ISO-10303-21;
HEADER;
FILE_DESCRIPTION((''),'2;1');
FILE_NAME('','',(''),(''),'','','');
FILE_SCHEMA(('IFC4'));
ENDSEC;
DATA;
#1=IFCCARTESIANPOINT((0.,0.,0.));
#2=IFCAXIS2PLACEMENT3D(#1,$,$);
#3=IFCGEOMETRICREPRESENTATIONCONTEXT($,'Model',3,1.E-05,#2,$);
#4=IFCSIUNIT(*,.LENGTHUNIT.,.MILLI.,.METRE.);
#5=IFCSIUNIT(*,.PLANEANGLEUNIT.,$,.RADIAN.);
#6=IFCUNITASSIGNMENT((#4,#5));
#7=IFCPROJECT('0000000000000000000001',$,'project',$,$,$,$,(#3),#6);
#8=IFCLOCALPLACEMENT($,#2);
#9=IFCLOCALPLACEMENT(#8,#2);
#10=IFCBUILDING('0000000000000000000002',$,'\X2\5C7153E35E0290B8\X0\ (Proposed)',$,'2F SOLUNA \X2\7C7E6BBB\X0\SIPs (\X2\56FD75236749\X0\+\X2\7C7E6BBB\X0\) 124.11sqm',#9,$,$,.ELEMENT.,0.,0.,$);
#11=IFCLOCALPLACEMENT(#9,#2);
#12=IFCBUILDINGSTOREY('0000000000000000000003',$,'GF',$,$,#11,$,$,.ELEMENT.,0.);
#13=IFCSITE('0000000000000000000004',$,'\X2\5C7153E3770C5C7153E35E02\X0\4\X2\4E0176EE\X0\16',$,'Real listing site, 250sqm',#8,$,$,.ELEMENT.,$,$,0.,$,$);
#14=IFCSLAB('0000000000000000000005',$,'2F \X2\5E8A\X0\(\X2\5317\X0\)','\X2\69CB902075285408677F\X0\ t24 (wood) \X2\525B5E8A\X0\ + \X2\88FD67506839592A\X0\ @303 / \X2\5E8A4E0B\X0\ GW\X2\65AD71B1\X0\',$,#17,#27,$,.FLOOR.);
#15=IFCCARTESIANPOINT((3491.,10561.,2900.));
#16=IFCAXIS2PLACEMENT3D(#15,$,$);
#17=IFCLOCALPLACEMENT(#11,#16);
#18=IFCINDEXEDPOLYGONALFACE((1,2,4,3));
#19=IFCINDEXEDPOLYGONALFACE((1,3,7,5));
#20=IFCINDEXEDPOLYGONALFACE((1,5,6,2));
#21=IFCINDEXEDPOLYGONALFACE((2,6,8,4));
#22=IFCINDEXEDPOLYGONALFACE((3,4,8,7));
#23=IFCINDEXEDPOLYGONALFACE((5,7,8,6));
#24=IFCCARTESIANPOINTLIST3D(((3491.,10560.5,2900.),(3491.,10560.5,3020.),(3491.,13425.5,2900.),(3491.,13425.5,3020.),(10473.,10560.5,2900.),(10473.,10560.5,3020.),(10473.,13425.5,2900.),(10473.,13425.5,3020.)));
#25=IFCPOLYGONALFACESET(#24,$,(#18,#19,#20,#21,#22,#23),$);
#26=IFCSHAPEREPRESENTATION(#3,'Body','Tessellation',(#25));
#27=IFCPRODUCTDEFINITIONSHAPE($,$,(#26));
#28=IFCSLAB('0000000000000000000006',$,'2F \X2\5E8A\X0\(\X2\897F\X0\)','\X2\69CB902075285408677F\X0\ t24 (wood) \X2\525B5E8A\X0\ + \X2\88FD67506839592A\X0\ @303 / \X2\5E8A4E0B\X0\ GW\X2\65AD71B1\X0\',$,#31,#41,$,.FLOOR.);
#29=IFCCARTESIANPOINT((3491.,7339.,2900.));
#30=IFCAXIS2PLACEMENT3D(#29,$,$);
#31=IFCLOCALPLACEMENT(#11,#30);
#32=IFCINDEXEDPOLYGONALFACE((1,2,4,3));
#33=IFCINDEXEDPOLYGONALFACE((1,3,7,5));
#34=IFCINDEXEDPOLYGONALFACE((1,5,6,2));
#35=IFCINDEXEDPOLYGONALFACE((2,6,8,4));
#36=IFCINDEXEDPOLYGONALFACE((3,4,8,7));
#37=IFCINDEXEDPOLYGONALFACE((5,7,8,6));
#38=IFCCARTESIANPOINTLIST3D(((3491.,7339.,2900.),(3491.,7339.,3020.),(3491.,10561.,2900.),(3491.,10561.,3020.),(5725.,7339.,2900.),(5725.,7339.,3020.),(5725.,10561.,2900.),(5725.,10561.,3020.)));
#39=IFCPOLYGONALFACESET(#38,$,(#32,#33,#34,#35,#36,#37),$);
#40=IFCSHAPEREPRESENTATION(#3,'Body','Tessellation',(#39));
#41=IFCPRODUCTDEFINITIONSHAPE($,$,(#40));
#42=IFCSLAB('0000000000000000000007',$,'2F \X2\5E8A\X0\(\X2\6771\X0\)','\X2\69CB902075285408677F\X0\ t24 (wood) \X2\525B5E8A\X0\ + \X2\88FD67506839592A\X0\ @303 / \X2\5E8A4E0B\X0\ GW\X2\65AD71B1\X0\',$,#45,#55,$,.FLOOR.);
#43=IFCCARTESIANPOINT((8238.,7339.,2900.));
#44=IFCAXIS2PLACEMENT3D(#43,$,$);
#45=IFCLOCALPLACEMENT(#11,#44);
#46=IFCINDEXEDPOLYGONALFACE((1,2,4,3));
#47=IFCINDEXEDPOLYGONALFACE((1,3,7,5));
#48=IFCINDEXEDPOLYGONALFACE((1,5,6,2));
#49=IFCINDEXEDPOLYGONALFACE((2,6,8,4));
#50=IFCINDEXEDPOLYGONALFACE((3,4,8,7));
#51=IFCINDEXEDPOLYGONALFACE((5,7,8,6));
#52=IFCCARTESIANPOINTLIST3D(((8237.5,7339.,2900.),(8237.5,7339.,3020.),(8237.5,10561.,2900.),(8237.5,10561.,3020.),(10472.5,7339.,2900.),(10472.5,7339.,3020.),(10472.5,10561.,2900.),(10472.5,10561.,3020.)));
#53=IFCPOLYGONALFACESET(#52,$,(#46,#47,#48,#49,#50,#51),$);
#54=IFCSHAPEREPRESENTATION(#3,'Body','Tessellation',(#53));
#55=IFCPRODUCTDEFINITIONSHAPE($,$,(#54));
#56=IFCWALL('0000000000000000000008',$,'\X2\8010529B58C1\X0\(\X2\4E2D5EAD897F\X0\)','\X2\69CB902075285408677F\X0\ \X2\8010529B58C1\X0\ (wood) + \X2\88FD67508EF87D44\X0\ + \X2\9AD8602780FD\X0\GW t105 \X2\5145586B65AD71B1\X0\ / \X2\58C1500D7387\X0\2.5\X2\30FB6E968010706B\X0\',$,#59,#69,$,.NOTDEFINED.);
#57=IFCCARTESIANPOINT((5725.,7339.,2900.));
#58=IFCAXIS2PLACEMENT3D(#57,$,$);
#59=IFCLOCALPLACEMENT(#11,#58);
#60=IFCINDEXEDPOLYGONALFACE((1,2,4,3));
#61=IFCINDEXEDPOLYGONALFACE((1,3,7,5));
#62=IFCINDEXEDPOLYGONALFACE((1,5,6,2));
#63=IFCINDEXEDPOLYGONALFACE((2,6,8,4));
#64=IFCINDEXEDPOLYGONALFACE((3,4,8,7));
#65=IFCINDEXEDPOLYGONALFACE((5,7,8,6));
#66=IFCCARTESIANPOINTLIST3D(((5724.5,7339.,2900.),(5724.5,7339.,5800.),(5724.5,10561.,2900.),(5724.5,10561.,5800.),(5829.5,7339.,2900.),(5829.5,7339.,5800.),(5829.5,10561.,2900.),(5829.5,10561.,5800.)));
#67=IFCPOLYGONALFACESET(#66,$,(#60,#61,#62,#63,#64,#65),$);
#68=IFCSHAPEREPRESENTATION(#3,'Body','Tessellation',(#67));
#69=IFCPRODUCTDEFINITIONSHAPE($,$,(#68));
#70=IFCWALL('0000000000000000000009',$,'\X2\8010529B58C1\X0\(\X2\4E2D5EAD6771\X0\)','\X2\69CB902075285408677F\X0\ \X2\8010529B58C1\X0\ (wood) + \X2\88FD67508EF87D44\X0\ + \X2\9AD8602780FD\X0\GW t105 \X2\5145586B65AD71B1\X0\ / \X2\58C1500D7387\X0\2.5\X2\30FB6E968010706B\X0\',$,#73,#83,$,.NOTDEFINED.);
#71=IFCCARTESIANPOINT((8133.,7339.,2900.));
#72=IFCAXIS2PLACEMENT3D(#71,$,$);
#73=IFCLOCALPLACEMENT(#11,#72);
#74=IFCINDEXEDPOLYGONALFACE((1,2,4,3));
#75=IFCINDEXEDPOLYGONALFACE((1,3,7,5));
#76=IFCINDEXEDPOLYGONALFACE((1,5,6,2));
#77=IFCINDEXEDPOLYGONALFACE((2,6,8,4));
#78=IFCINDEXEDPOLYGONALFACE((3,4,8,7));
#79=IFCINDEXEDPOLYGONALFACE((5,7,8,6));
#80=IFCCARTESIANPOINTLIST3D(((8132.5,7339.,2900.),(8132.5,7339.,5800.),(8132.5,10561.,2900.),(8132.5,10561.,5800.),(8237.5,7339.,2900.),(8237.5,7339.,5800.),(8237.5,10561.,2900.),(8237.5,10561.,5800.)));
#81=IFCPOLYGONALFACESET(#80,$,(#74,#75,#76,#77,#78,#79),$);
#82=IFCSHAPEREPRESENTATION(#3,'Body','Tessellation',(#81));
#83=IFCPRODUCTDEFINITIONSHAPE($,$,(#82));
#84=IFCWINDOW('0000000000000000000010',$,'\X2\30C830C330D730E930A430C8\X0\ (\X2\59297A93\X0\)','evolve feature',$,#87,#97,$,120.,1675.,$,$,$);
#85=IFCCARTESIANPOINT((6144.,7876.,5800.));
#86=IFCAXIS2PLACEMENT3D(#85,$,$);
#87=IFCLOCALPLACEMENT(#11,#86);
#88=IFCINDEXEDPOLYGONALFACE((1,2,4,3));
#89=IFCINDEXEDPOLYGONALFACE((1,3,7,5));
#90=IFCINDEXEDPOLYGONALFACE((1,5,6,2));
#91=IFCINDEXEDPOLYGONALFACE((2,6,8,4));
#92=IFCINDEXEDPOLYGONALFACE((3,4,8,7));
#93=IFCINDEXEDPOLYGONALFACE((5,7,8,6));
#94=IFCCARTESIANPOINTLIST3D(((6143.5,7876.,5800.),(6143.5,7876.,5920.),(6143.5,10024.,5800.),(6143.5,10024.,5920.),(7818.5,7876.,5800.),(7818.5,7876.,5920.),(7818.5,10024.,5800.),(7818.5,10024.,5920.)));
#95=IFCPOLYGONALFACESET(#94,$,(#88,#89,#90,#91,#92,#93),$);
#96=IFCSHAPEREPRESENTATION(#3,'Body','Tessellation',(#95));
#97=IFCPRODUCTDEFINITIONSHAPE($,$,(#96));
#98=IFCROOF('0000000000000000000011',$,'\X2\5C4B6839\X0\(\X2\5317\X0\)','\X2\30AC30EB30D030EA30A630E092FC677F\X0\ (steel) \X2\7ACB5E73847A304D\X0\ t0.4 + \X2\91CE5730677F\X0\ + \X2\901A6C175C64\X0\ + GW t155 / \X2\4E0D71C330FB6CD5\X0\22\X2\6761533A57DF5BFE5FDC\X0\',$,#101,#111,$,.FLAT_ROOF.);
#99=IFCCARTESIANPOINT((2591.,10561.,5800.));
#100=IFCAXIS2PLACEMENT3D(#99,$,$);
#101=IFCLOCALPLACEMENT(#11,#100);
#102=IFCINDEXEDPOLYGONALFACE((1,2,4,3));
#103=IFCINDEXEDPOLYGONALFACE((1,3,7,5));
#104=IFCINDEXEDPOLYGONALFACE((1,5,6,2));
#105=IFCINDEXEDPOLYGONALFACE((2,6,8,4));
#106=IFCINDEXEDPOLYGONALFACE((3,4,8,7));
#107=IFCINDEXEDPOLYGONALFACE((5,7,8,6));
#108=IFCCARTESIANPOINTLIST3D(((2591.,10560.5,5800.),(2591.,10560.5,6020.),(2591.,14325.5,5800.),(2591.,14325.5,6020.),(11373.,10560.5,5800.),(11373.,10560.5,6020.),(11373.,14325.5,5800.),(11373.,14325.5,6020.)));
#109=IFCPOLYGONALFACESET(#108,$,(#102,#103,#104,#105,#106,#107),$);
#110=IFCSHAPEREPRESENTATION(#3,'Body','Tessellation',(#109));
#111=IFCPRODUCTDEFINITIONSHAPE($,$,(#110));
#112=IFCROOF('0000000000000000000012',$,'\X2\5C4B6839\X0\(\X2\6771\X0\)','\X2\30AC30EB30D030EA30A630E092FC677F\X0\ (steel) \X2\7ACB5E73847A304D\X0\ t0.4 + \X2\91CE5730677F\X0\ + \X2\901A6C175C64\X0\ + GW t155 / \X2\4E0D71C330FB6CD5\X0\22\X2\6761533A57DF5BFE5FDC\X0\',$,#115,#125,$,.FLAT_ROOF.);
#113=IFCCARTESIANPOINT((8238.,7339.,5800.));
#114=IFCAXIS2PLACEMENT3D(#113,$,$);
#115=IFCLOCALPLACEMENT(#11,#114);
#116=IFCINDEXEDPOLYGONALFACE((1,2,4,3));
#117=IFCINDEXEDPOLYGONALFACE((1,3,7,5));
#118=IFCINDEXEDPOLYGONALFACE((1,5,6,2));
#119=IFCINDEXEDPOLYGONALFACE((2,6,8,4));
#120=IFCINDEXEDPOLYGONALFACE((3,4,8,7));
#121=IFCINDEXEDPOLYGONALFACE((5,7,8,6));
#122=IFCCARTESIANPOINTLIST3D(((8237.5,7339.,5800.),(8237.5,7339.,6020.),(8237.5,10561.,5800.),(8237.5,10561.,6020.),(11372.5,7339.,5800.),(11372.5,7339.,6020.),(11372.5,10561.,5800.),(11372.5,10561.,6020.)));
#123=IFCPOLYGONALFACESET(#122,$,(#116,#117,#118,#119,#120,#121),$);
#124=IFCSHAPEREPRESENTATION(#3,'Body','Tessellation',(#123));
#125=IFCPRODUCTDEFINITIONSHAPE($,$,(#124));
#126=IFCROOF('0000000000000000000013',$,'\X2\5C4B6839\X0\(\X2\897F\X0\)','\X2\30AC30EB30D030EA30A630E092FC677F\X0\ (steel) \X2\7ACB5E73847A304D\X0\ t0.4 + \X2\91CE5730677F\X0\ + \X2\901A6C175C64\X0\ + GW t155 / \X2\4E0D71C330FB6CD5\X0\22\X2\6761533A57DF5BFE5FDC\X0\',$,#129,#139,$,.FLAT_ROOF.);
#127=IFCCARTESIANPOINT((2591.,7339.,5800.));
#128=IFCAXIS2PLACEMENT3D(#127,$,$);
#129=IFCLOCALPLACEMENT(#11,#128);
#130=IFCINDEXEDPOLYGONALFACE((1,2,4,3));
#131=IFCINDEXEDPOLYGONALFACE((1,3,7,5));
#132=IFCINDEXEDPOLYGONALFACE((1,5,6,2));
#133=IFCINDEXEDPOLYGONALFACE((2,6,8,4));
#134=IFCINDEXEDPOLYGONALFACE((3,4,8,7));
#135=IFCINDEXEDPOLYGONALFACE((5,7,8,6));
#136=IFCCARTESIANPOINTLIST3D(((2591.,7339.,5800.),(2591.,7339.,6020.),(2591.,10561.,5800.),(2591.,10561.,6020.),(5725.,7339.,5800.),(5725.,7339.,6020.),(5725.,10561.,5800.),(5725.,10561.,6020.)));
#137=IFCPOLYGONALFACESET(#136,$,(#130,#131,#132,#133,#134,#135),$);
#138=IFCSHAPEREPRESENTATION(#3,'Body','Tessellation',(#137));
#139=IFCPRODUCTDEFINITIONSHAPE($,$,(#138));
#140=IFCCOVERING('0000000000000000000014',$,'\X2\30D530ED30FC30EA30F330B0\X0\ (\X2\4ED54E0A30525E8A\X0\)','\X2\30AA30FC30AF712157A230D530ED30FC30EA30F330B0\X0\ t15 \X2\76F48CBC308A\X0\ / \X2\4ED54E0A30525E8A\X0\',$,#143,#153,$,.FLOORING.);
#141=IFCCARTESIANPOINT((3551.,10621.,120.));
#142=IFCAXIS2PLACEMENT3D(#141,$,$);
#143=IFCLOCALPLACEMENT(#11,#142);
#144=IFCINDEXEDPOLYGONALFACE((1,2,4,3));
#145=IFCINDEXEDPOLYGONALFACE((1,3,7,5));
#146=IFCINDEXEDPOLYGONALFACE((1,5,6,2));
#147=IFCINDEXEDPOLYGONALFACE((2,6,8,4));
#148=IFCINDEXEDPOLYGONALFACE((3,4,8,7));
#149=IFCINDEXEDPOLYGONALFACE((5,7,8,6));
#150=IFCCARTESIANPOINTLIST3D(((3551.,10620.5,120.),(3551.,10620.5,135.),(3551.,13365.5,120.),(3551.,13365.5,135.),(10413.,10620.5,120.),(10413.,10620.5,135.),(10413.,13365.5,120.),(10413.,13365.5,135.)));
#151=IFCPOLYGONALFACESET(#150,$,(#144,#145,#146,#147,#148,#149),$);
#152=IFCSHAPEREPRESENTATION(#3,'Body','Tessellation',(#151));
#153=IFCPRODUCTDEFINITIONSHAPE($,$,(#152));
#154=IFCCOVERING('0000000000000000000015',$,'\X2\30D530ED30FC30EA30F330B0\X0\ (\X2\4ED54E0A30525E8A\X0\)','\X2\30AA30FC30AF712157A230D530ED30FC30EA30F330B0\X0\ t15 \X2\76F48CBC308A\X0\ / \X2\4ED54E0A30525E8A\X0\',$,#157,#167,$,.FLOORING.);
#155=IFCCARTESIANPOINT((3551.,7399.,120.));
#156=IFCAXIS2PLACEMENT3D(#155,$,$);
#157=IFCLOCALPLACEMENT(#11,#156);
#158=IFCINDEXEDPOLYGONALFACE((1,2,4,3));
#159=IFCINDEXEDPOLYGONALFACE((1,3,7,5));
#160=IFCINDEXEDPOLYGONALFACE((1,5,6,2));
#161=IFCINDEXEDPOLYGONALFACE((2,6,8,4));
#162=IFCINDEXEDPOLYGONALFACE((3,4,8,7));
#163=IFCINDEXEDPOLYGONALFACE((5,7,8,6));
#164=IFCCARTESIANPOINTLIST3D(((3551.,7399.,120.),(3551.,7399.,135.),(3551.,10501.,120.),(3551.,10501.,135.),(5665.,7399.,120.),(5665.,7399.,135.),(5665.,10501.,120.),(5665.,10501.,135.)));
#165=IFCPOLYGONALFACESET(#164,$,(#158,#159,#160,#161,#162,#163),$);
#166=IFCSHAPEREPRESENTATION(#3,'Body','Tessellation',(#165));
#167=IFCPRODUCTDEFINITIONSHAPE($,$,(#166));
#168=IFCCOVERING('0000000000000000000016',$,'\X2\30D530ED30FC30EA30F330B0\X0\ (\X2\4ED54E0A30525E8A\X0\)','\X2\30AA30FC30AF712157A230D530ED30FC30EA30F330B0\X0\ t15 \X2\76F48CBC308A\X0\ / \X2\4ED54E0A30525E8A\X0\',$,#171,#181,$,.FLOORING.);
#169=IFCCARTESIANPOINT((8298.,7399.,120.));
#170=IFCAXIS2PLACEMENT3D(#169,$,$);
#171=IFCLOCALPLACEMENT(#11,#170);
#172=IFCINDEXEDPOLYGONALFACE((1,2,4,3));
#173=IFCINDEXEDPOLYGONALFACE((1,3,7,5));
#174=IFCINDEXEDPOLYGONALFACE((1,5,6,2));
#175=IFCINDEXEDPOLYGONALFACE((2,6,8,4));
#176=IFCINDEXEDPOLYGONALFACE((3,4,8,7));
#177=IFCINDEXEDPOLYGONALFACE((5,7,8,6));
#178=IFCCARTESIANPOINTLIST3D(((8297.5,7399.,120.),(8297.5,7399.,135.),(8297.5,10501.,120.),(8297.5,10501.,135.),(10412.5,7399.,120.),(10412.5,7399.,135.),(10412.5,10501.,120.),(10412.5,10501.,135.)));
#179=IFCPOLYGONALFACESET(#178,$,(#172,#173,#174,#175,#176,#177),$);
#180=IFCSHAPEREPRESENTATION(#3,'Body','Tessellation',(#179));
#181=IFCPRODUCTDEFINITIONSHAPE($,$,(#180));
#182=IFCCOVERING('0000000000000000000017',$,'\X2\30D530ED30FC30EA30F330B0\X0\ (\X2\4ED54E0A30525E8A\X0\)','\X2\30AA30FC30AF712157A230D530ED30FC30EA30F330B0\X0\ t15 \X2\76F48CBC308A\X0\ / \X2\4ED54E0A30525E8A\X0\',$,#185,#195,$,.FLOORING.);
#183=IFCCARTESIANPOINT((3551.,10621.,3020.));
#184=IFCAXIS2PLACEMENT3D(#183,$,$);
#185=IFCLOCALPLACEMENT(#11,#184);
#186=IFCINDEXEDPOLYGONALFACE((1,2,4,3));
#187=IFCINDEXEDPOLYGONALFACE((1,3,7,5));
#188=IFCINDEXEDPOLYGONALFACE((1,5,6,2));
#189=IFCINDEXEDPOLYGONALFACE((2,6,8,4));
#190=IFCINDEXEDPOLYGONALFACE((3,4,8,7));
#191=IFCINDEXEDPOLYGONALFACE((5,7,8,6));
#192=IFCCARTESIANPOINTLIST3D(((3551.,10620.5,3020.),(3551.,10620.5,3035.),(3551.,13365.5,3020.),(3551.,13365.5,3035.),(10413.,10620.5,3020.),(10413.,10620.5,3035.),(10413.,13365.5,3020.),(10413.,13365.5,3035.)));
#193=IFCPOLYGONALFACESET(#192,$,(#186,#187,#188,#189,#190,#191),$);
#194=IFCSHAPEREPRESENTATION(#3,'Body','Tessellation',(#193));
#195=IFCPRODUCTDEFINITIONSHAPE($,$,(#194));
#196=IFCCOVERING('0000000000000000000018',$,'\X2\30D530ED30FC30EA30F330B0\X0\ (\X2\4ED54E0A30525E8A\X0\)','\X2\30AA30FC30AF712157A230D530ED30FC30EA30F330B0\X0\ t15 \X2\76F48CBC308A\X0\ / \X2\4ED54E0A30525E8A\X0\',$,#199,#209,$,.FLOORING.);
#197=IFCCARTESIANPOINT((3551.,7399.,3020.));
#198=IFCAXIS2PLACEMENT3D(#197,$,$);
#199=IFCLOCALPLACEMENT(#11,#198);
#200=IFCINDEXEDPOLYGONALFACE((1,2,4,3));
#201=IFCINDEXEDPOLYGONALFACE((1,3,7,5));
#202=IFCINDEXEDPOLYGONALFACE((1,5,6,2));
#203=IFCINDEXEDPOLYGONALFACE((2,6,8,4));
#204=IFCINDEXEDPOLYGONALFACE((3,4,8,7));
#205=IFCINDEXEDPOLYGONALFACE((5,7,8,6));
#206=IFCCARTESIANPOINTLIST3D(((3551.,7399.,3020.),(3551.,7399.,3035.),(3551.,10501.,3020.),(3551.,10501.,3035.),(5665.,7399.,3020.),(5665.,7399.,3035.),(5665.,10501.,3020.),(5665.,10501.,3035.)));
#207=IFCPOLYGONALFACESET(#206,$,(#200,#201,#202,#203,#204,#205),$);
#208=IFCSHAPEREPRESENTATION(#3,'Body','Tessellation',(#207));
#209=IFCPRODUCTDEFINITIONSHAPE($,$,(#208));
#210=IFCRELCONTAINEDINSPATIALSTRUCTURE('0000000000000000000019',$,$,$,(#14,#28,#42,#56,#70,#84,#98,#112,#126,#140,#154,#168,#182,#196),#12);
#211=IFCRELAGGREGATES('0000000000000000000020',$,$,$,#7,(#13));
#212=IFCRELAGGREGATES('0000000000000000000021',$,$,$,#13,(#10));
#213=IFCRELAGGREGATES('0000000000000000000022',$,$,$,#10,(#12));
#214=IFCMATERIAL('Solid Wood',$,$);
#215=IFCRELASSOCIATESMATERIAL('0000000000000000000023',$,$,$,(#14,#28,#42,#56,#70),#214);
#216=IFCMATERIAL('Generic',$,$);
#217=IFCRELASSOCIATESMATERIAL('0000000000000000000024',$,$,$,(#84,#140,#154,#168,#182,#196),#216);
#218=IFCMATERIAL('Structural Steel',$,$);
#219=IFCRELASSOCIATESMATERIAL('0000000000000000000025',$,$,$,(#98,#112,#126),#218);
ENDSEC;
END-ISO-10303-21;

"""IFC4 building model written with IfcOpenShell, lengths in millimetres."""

from ifc_helpers import new_model, si_unit, frame, frame_2d, origin, place, context, project, spatial, rectangle, extrude, material, element, save


model = new_model("IFC4")

# Units and contexts
model_context = context("Model", 3, precision=1e-05, world=origin())
ifc_project = project(units=[si_unit("LENGTHUNIT", "METRE", prefix="MILLI"), si_unit("PLANEANGLEUNIT", "RADIAN")], contexts=[model_context])

# Site, building, storey
site_placement = place(None, origin())
site = spatial("IfcSite", under=ifc_project, at=site_placement, Name="山口県山口市4丁目16", ObjectType="Real listing site, 250sqm", CompositionType="ELEMENT", RefElevation=0.0)
building_placement = place(site_placement, origin())
building = spatial("IfcBuilding", under=site, at=building_placement, Name="山口市邸 (Proposed)", ObjectType="2F SOLUNA 籾殻SIPs (国産杉+籾殻) 124.11sqm", CompositionType="ELEMENT", ElevationOfRefHeight=0.0, ElevationOfTerrain=0.0)
storey_placement = place(building_placement, origin())
storey = spatial("IfcBuildingStorey", under=building, at=storey_placement, Name="GF", CompositionType="ELEMENT", Elevation=0.0)

# Slabs
ifc_material_1 = material(Name="Solid Wood")
slab_1_placement = place(storey_placement, frame((3491.0, 10561.0, 2900.0)))
element("IfcSlab", 1, at=slab_1_placement, inside=storey, material=ifc_material_1, Name="2F 床(北)", Description="構造用合板 t24 (wood) 剛床 + 製材根太 @303 / 床下 GW断熱", PredefinedType="FLOOR", context=model_context, shape_type="SweptSolid", body=[
    extrude(rectangle(XDim=6982.0, YDim=2865.0, at=frame_2d((3491.0, 1432.0))), frame((3491.0, 10561.0, 2900.0)), (0.0, 0.0, 1.0), 120.0),
])
slab_2_placement = place(storey_placement, frame((3491.0, 7339.0, 2900.0)))
element("IfcSlab", 2, at=slab_2_placement, inside=storey, material=ifc_material_1, Name="2F 床(西)", Description="構造用合板 t24 (wood) 剛床 + 製材根太 @303 / 床下 GW断熱", PredefinedType="FLOOR", context=model_context, shape_type="SweptSolid", body=[
    extrude(rectangle(XDim=2234.0, YDim=3222.0, at=frame_2d((1117.0, 1611.0))), frame((3491.0, 7339.0, 2900.0)), (0.0, 0.0, 1.0), 120.0),
])
slab_3_placement = place(storey_placement, frame((8238.0, 7339.0, 2900.0)))
element("IfcSlab", 3, at=slab_3_placement, inside=storey, material=ifc_material_1, Name="2F 床(東)", Description="構造用合板 t24 (wood) 剛床 + 製材根太 @303 / 床下 GW断熱", PredefinedType="FLOOR", context=model_context, shape_type="SweptSolid", body=[
    extrude(rectangle(XDim=2235.0, YDim=3222.0, at=frame_2d((1117.0, 1611.0))), frame((8238.0, 7339.0, 2900.0)), (0.0, 0.0, 1.0), 120.0),
])

# Walls
wall_1_placement = place(storey_placement, frame((5725.0, 7339.0, 2900.0)))
element("IfcWall", 4, at=wall_1_placement, inside=storey, material=ifc_material_1, Name="耐力壁(中庭西)", Description="構造用合板 耐力壁 (wood) + 製材軸組 + 高性能GW t105 充填断熱 / 壁倍率2.5・準耐火", PredefinedType="NOTDEFINED", context=model_context, shape_type="SweptSolid", body=[
    extrude(rectangle(XDim=105.0, YDim=3222.0, at=frame_2d((52.0, 1611.0))), frame((5725.0, 7339.0, 2900.0)), (0.0, 0.0, 1.0), 2900.0),
])
wall_2_placement = place(storey_placement, frame((8133.0, 7339.0, 2900.0)))
element("IfcWall", 5, at=wall_2_placement, inside=storey, material=ifc_material_1, Name="耐力壁(中庭東)", Description="構造用合板 耐力壁 (wood) + 製材軸組 + 高性能GW t105 充填断熱 / 壁倍率2.5・準耐火", PredefinedType="NOTDEFINED", context=model_context, shape_type="SweptSolid", body=[
    extrude(rectangle(XDim=105.0, YDim=3222.0, at=frame_2d((52.0, 1611.0))), frame((8133.0, 7339.0, 2900.0)), (0.0, 0.0, 1.0), 2900.0),
])

# Window
ifc_material_2 = material(Name="Generic")
window_1_placement = place(storey_placement, frame((6144.0, 7876.0, 5800.0)))
element("IfcWindow", 6, at=window_1_placement, inside=storey, material=ifc_material_2, Name="トップライト (天窓)", Description="evolve feature", OverallHeight=120.0, OverallWidth=1675.0, context=model_context, shape_type="SweptSolid", body=[
    extrude(rectangle(XDim=1675.0, YDim=2148.0, at=frame_2d((837.0, 1074.0))), frame((6144.0, 7876.0, 5800.0)), (0.0, 0.0, 1.0), 120.0),
])

# Roofs
ifc_material_3 = material(Name="Structural Steel")
roof_1_placement = place(storey_placement, frame((2591.0, 10561.0, 5800.0)))
element("IfcRoof", 7, at=roof_1_placement, inside=storey, material=ifc_material_3, Name="屋根(北)", Description="ガルバリウム鋼板 (steel) 立平葺き t0.4 + 野地板 + 通気層 + GW t155 / 不燃・法22条区域対応", PredefinedType="FLAT_ROOF", context=model_context, shape_type="SweptSolid", body=[
    extrude(rectangle(XDim=8782.0, YDim=3765.0, at=frame_2d((4391.0, 1882.0))), frame((2591.0, 10561.0, 5800.0)), (0.0, 0.0, 1.0), 220.0),
])
roof_2_placement = place(storey_placement, frame((8238.0, 7339.0, 5800.0)))
element("IfcRoof", 8, at=roof_2_placement, inside=storey, material=ifc_material_3, Name="屋根(東)", Description="ガルバリウム鋼板 (steel) 立平葺き t0.4 + 野地板 + 通気層 + GW t155 / 不燃・法22条区域対応", PredefinedType="FLAT_ROOF", context=model_context, shape_type="SweptSolid", body=[
    extrude(rectangle(XDim=3135.0, YDim=3222.0, at=frame_2d((1567.0, 1611.0))), frame((8238.0, 7339.0, 5800.0)), (0.0, 0.0, 1.0), 220.0),
])
roof_3_placement = place(storey_placement, frame((2591.0, 7339.0, 5800.0)))
element("IfcRoof", 9, at=roof_3_placement, inside=storey, material=ifc_material_3, Name="屋根(西)", Description="ガルバリウム鋼板 (steel) 立平葺き t0.4 + 野地板 + 通気層 + GW t155 / 不燃・法22条区域対応", PredefinedType="FLAT_ROOF", context=model_context, shape_type="SweptSolid", body=[
    extrude(rectangle(XDim=3134.0, YDim=3222.0, at=frame_2d((1567.0, 1611.0))), frame((2591.0, 7339.0, 5800.0)), (0.0, 0.0, 1.0), 220.0),
])

# Coverings
covering_1_placement = place(storey_placement, frame((3551.0, 10621.0, 120.0)))
element("IfcCovering", 10, at=covering_1_placement, inside=storey, material=ifc_material_2, Name="フローリング (仕上げ床)", Description="オーク無垢フローリング t15 直貼り / 仕上げ床", PredefinedType="FLOORING", context=model_context, shape_type="SweptSolid", body=[
    extrude(rectangle(XDim=6862.0, YDim=2745.0, at=frame_2d((3431.0, 1372.0))), frame((3551.0, 10621.0, 120.0)), (0.0, 0.0, 1.0), 15.0),
])
covering_2_placement = place(storey_placement, frame((3551.0, 7399.0, 120.0)))
element("IfcCovering", 11, at=covering_2_placement, inside=storey, material=ifc_material_2, Name="フローリング (仕上げ床)", Description="オーク無垢フローリング t15 直貼り / 仕上げ床", PredefinedType="FLOORING", context=model_context, shape_type="SweptSolid", body=[
    extrude(rectangle(XDim=2114.0, YDim=3102.0, at=frame_2d((1057.0, 1551.0))), frame((3551.0, 7399.0, 120.0)), (0.0, 0.0, 1.0), 15.0),
])
covering_3_placement = place(storey_placement, frame((8298.0, 7399.0, 120.0)))
element("IfcCovering", 12, at=covering_3_placement, inside=storey, material=ifc_material_2, Name="フローリング (仕上げ床)", Description="オーク無垢フローリング t15 直貼り / 仕上げ床", PredefinedType="FLOORING", context=model_context, shape_type="SweptSolid", body=[
    extrude(rectangle(XDim=2115.0, YDim=3102.0, at=frame_2d((1057.0, 1551.0))), frame((8298.0, 7399.0, 120.0)), (0.0, 0.0, 1.0), 15.0),
])
covering_4_placement = place(storey_placement, frame((3551.0, 10621.0, 3020.0)))
element("IfcCovering", 13, at=covering_4_placement, inside=storey, material=ifc_material_2, Name="フローリング (仕上げ床)", Description="オーク無垢フローリング t15 直貼り / 仕上げ床", PredefinedType="FLOORING", context=model_context, shape_type="SweptSolid", body=[
    extrude(rectangle(XDim=6862.0, YDim=2745.0, at=frame_2d((3431.0, 1372.0))), frame((3551.0, 10621.0, 3020.0)), (0.0, 0.0, 1.0), 15.0),
])
covering_5_placement = place(storey_placement, frame((3551.0, 7399.0, 3020.0)))
element("IfcCovering", 14, at=covering_5_placement, inside=storey, material=ifc_material_2, Name="フローリング (仕上げ床)", Description="オーク無垢フローリング t15 直貼り / 仕上げ床", PredefinedType="FLOORING", context=model_context, shape_type="SweptSolid", body=[
    extrude(rectangle(XDim=2114.0, YDim=3102.0, at=frame_2d((1057.0, 1551.0))), frame((3551.0, 7399.0, 3020.0)), (0.0, 0.0, 1.0), 15.0),
])

save(model, "model.ifc")
